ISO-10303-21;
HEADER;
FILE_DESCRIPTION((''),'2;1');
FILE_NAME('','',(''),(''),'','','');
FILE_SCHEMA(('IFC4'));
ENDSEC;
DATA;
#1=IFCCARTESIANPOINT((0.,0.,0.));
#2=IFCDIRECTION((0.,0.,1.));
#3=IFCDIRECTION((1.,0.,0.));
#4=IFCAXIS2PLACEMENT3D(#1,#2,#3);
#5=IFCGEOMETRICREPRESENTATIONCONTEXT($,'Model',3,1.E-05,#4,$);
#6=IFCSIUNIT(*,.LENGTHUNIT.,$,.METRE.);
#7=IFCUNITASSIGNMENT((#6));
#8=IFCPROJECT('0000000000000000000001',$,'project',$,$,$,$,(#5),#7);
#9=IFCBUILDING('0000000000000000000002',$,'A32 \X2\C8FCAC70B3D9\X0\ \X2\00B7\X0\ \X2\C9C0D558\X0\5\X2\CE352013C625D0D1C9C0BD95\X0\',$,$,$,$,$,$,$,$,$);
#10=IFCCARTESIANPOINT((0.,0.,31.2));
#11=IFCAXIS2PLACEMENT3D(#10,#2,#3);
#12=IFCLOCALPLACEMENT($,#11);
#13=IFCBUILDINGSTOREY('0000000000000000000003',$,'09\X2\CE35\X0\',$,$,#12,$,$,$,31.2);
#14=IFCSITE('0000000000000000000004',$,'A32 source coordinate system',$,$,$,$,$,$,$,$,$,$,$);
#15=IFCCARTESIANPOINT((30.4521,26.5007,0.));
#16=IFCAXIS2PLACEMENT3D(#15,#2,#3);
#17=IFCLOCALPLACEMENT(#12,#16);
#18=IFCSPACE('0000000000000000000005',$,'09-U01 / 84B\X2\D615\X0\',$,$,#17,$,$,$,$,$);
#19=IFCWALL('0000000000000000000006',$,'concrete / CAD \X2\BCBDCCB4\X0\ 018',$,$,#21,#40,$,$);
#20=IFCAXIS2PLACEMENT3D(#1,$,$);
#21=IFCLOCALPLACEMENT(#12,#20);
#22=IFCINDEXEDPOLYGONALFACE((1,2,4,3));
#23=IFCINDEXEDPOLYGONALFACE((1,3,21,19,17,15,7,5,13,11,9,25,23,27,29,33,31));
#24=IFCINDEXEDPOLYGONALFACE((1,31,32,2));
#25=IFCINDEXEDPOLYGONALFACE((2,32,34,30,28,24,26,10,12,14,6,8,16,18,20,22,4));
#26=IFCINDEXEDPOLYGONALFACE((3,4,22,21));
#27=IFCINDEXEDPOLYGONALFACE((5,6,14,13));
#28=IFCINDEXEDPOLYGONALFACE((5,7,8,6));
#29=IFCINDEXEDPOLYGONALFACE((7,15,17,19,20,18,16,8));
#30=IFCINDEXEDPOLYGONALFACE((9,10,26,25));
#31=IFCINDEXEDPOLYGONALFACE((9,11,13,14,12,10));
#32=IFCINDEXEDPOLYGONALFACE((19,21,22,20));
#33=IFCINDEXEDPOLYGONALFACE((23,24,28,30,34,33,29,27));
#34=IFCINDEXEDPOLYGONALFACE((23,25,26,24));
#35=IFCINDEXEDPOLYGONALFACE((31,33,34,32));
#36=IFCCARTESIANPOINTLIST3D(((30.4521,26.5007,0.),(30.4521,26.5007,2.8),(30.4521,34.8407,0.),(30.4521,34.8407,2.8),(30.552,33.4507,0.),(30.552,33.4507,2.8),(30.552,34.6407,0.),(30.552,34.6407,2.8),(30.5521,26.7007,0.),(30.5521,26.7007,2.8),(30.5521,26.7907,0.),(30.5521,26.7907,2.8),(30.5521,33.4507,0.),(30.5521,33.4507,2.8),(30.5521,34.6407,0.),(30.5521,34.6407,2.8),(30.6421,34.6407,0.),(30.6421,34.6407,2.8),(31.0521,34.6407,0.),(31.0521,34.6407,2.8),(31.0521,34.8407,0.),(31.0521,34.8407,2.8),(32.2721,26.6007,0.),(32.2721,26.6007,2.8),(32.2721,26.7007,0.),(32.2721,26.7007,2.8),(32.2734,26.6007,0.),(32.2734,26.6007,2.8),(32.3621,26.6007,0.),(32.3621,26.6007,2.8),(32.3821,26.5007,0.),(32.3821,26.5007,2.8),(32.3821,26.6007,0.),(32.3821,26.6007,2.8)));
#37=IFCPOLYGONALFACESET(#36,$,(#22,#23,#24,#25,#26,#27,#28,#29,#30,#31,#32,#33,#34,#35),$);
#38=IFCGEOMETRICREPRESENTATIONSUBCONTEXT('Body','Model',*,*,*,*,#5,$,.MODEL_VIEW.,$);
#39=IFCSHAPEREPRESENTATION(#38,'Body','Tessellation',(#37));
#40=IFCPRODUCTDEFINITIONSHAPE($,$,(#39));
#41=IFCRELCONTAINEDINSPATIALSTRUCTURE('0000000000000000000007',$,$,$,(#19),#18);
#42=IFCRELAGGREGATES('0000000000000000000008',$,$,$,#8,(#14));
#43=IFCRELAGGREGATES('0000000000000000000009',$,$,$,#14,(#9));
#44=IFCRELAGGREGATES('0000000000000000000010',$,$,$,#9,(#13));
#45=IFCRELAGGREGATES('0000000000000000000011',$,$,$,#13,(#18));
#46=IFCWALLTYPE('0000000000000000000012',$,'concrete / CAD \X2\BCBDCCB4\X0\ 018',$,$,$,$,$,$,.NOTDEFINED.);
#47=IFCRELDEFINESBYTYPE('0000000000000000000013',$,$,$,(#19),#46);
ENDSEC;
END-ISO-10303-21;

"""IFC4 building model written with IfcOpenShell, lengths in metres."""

from ifc_helpers import new_model, si_unit, frame, origin, origin_with_axes, place, context, subcontext, project, spatial, polyline, outline, extrude, source, transform, mapped, type_object, type_shapes, element, save


model = new_model("IFC4")

# Units and contexts
model_context = context("Model", 3, precision=1e-05, world=origin_with_axes())
body_context = subcontext(model_context, "Body", "Model", "MODEL_VIEW")
ifc_project = project(units=[si_unit("LENGTHUNIT", "METRE")], contexts=[model_context])

# Site, building, storey, space
site = spatial("IfcSite", under=ifc_project, Name="A32 source coordinate system")
building = spatial("IfcBuilding", under=site, Name="A32 주거동 · 지하5층–옥탑지붕")
storey_placement = place(None, frame((0.0, 0.0, 31.2), z_axis=(0.0, 0.0, 1.0), x_axis=(1.0, 0.0, 0.0)))
storey = spatial("IfcBuildingStorey", under=building, at=storey_placement, Name="09층", Elevation=31.2)
space_1_placement = place(storey_placement, frame((30.4521, 26.5007, 0.0), z_axis=(0.0, 0.0, 1.0), x_axis=(1.0, 0.0, 0.0)))
space_1 = spatial("IfcSpace", under=storey, at=space_1_placement, Name="09-U01 / 84B형")

# Wall
wall_type_1 = type_object("IfcWallType", Name="concrete / CAD 벽체 018", PredefinedType="NOTDEFINED")
shared_shape_1 = source(origin(), body_context, "Body", "SweptSolid", [
    extrude(outline(polyline([(0.6, 8.34), (0.6, 8.14), (0.19, 8.14), (0.1, 8.14), (0.0999, 8.14), (0.0999, 6.95), (0.1, 6.95), (0.1, 0.29), (0.1, 0.2), (1.82, 0.2), (1.82, 0.1), (1.8213, 0.1), (1.91, 0.1), (1.93, 0.1), (1.93, 0.0), (0.0, 0.0), (0.0, 8.34), (-0.35, 8.34), (-0.35, 8.34), (0.6, 8.34)])), origin(), (0.0, 0.0, 1.0), 2.8),
])
type_shapes(wall_type_1, [shared_shape_1])
wall_1_placement = place(space_1_placement, origin_with_axes())
element("IfcWall", 1, at=wall_1_placement, inside=space_1, type_object=wall_type_1, Name="concrete / CAD 벽체 018", context=body_context, shape_type="MappedRepresentation", body=[
    mapped(shared_shape_1, transform((0.0, 0.0, 0.0), scale=1.0)),
])

save(model, "model.ifc")
